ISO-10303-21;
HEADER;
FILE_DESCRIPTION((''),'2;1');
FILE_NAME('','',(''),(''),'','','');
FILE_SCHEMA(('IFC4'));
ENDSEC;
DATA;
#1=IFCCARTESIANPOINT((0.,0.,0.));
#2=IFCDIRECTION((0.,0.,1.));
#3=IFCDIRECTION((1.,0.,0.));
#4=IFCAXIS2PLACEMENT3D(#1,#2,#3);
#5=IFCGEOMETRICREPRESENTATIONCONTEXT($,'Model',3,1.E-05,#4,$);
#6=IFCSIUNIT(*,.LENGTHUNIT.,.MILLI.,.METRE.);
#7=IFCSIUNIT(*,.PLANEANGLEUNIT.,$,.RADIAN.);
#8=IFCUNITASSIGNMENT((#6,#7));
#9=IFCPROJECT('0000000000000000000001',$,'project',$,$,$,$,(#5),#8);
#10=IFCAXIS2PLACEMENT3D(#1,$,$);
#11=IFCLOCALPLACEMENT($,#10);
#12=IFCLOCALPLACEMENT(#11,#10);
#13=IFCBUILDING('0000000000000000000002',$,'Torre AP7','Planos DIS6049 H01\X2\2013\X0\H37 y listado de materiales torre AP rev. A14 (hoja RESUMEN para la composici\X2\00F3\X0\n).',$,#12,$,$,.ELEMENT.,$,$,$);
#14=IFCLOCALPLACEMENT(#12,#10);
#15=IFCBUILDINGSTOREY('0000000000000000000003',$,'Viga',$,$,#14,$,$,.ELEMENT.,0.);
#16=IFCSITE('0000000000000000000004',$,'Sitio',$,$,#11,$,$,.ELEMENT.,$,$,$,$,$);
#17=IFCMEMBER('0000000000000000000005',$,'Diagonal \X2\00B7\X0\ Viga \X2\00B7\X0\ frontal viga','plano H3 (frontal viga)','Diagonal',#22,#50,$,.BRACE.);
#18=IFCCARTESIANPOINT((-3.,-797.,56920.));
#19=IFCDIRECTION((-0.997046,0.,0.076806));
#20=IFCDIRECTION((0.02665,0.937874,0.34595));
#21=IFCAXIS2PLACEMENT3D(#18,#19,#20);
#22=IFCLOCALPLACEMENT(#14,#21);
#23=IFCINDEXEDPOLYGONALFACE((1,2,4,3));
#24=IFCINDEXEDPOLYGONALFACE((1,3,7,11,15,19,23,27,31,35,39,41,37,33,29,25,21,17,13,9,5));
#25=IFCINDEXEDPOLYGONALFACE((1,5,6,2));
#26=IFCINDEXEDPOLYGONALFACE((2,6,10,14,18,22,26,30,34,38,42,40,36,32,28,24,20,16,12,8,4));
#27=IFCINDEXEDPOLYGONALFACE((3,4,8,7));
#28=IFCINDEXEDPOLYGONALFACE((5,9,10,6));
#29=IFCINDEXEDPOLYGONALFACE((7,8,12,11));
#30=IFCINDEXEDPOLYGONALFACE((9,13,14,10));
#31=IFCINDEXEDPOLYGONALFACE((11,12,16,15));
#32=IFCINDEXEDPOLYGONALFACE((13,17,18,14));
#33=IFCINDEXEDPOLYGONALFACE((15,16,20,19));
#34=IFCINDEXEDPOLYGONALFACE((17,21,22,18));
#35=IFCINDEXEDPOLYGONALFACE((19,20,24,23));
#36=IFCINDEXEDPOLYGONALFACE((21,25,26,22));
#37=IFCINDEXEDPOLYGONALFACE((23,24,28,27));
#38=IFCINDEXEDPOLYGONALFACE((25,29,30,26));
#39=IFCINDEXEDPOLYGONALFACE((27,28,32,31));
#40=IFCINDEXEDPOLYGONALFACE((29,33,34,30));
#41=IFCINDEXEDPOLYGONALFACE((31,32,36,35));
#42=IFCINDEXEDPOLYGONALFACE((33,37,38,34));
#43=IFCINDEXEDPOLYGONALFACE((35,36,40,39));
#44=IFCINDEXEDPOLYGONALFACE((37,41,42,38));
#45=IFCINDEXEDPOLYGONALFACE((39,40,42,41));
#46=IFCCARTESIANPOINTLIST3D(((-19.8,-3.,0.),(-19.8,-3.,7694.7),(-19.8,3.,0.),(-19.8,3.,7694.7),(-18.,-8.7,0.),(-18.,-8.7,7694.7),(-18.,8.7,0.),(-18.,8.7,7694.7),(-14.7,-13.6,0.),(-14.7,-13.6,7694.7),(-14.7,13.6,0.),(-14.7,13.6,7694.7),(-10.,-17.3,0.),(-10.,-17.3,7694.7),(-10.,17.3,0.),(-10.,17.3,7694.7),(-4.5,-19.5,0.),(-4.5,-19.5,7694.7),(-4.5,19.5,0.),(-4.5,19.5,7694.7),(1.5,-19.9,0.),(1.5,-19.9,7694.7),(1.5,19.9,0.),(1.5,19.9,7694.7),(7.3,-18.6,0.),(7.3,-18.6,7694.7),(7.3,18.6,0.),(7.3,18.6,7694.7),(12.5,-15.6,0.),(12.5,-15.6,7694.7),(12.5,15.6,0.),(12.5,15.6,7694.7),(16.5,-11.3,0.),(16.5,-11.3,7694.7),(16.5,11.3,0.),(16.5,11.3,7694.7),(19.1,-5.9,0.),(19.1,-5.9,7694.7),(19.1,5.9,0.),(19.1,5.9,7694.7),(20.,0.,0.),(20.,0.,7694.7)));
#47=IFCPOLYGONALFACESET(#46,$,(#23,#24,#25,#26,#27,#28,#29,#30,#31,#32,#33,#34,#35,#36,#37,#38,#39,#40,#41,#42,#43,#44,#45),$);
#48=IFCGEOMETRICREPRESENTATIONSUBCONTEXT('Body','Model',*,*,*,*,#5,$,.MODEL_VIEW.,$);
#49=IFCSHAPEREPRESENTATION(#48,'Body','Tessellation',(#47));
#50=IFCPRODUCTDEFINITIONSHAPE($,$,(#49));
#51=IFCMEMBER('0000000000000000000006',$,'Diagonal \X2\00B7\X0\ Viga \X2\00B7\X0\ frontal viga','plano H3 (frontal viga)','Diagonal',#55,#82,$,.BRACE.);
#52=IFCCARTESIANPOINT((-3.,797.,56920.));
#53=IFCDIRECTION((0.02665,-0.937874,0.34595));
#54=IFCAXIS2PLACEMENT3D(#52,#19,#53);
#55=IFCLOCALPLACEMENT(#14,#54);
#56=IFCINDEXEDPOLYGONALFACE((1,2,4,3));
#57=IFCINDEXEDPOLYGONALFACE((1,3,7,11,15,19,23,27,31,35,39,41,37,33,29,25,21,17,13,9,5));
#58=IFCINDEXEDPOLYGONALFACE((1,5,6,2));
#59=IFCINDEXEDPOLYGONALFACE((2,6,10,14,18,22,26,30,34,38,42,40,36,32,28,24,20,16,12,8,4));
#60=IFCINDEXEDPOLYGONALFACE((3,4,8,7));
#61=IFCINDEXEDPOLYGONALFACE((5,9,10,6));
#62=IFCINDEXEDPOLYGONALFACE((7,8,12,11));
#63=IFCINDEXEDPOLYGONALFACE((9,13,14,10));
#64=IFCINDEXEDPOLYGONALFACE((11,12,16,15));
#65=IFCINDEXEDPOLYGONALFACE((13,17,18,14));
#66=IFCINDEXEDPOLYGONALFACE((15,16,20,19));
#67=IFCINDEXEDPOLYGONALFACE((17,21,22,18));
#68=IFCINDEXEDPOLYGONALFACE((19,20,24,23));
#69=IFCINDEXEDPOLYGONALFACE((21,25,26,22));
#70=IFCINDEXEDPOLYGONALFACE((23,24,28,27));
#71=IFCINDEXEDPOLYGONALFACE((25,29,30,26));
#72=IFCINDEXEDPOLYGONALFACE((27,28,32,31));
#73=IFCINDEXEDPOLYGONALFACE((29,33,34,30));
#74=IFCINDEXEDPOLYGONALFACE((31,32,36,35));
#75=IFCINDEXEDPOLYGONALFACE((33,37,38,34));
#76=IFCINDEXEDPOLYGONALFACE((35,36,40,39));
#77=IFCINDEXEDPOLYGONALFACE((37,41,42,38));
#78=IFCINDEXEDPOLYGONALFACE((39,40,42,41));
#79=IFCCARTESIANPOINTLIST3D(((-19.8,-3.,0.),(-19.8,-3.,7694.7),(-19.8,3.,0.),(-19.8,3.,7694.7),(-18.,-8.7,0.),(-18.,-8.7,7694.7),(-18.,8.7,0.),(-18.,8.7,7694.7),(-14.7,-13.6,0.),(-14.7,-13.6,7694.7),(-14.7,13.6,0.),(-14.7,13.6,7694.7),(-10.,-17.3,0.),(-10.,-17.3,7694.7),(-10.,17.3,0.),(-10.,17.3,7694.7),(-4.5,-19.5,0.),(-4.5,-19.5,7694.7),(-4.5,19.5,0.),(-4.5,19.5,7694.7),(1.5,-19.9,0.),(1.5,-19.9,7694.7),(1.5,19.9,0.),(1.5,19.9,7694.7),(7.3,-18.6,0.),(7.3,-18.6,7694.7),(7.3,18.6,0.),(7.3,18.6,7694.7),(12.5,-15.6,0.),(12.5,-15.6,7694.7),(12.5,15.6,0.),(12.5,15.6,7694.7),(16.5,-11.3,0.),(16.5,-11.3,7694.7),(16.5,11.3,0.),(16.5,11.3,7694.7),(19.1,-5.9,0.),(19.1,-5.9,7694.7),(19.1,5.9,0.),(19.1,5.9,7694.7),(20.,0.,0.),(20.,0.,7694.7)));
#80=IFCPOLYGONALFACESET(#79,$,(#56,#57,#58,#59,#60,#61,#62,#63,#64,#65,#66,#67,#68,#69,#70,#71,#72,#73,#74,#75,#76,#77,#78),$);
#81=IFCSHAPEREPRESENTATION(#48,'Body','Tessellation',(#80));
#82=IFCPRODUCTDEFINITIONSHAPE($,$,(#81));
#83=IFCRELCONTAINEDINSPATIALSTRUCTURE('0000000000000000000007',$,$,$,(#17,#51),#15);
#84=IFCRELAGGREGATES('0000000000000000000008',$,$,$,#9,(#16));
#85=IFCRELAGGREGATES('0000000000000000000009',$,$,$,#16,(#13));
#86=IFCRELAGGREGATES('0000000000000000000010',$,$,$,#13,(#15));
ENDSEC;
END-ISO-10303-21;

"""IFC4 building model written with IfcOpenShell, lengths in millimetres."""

from ifc_helpers import new_model, si_unit, frame, origin, origin_with_axes, place, context, subcontext, project, spatial, circle, extrude, element, save


model = new_model("IFC4")

# Units and contexts
model_context = context("Model", 3, precision=1e-05, world=origin_with_axes())
body_context = subcontext(model_context, "Body", "Model", "MODEL_VIEW")
ifc_project = project(units=[si_unit("LENGTHUNIT", "METRE", prefix="MILLI"), si_unit("PLANEANGLEUNIT", "RADIAN")], contexts=[model_context])

# Site, building, storey
site_placement = place(None, origin())
site = spatial("IfcSite", under=ifc_project, at=site_placement, Name="Sitio", CompositionType="ELEMENT")
building_placement = place(site_placement, origin())
building = spatial("IfcBuilding", under=site, at=building_placement, Name="Torre AP7", Description="Planos DIS6049 H01–H37 y listado de materiales torre AP rev. A14 (hoja RESUMEN para la composición).", CompositionType="ELEMENT")
storey_placement = place(building_placement, origin())
storey = spatial("IfcBuildingStorey", under=building, at=storey_placement, Name="Viga", CompositionType="ELEMENT", Elevation=0.0)

# Members
for number, where, z_axis, x_axis, name in (
    (1, (-3.0, -797.0, 56920.0), (-0.997046, 0.0, 0.076806), (0.02665, 0.937874, 0.34595), "Diagonal · Viga · frontal viga"),
    (2, (-3.0, 797.0, 56920.0), (-0.997046, 0.0, 0.076806), (0.02665, -0.937874, 0.34595), "Diagonal · Viga · frontal viga"),
):
    element("IfcMember", number, at=place(storey_placement, frame(where, z_axis=z_axis, x_axis=x_axis)), inside=storey, Name=name, Description="plano H3 (frontal viga)", ObjectType="Diagonal", PredefinedType="BRACE", context=body_context, shape_type="SweptSolid", body=[
        extrude(circle(Radius=20.0), None, (0.0, 0.0, 1.0), 7694.7),
    ])

save(model, "model.ifc")
